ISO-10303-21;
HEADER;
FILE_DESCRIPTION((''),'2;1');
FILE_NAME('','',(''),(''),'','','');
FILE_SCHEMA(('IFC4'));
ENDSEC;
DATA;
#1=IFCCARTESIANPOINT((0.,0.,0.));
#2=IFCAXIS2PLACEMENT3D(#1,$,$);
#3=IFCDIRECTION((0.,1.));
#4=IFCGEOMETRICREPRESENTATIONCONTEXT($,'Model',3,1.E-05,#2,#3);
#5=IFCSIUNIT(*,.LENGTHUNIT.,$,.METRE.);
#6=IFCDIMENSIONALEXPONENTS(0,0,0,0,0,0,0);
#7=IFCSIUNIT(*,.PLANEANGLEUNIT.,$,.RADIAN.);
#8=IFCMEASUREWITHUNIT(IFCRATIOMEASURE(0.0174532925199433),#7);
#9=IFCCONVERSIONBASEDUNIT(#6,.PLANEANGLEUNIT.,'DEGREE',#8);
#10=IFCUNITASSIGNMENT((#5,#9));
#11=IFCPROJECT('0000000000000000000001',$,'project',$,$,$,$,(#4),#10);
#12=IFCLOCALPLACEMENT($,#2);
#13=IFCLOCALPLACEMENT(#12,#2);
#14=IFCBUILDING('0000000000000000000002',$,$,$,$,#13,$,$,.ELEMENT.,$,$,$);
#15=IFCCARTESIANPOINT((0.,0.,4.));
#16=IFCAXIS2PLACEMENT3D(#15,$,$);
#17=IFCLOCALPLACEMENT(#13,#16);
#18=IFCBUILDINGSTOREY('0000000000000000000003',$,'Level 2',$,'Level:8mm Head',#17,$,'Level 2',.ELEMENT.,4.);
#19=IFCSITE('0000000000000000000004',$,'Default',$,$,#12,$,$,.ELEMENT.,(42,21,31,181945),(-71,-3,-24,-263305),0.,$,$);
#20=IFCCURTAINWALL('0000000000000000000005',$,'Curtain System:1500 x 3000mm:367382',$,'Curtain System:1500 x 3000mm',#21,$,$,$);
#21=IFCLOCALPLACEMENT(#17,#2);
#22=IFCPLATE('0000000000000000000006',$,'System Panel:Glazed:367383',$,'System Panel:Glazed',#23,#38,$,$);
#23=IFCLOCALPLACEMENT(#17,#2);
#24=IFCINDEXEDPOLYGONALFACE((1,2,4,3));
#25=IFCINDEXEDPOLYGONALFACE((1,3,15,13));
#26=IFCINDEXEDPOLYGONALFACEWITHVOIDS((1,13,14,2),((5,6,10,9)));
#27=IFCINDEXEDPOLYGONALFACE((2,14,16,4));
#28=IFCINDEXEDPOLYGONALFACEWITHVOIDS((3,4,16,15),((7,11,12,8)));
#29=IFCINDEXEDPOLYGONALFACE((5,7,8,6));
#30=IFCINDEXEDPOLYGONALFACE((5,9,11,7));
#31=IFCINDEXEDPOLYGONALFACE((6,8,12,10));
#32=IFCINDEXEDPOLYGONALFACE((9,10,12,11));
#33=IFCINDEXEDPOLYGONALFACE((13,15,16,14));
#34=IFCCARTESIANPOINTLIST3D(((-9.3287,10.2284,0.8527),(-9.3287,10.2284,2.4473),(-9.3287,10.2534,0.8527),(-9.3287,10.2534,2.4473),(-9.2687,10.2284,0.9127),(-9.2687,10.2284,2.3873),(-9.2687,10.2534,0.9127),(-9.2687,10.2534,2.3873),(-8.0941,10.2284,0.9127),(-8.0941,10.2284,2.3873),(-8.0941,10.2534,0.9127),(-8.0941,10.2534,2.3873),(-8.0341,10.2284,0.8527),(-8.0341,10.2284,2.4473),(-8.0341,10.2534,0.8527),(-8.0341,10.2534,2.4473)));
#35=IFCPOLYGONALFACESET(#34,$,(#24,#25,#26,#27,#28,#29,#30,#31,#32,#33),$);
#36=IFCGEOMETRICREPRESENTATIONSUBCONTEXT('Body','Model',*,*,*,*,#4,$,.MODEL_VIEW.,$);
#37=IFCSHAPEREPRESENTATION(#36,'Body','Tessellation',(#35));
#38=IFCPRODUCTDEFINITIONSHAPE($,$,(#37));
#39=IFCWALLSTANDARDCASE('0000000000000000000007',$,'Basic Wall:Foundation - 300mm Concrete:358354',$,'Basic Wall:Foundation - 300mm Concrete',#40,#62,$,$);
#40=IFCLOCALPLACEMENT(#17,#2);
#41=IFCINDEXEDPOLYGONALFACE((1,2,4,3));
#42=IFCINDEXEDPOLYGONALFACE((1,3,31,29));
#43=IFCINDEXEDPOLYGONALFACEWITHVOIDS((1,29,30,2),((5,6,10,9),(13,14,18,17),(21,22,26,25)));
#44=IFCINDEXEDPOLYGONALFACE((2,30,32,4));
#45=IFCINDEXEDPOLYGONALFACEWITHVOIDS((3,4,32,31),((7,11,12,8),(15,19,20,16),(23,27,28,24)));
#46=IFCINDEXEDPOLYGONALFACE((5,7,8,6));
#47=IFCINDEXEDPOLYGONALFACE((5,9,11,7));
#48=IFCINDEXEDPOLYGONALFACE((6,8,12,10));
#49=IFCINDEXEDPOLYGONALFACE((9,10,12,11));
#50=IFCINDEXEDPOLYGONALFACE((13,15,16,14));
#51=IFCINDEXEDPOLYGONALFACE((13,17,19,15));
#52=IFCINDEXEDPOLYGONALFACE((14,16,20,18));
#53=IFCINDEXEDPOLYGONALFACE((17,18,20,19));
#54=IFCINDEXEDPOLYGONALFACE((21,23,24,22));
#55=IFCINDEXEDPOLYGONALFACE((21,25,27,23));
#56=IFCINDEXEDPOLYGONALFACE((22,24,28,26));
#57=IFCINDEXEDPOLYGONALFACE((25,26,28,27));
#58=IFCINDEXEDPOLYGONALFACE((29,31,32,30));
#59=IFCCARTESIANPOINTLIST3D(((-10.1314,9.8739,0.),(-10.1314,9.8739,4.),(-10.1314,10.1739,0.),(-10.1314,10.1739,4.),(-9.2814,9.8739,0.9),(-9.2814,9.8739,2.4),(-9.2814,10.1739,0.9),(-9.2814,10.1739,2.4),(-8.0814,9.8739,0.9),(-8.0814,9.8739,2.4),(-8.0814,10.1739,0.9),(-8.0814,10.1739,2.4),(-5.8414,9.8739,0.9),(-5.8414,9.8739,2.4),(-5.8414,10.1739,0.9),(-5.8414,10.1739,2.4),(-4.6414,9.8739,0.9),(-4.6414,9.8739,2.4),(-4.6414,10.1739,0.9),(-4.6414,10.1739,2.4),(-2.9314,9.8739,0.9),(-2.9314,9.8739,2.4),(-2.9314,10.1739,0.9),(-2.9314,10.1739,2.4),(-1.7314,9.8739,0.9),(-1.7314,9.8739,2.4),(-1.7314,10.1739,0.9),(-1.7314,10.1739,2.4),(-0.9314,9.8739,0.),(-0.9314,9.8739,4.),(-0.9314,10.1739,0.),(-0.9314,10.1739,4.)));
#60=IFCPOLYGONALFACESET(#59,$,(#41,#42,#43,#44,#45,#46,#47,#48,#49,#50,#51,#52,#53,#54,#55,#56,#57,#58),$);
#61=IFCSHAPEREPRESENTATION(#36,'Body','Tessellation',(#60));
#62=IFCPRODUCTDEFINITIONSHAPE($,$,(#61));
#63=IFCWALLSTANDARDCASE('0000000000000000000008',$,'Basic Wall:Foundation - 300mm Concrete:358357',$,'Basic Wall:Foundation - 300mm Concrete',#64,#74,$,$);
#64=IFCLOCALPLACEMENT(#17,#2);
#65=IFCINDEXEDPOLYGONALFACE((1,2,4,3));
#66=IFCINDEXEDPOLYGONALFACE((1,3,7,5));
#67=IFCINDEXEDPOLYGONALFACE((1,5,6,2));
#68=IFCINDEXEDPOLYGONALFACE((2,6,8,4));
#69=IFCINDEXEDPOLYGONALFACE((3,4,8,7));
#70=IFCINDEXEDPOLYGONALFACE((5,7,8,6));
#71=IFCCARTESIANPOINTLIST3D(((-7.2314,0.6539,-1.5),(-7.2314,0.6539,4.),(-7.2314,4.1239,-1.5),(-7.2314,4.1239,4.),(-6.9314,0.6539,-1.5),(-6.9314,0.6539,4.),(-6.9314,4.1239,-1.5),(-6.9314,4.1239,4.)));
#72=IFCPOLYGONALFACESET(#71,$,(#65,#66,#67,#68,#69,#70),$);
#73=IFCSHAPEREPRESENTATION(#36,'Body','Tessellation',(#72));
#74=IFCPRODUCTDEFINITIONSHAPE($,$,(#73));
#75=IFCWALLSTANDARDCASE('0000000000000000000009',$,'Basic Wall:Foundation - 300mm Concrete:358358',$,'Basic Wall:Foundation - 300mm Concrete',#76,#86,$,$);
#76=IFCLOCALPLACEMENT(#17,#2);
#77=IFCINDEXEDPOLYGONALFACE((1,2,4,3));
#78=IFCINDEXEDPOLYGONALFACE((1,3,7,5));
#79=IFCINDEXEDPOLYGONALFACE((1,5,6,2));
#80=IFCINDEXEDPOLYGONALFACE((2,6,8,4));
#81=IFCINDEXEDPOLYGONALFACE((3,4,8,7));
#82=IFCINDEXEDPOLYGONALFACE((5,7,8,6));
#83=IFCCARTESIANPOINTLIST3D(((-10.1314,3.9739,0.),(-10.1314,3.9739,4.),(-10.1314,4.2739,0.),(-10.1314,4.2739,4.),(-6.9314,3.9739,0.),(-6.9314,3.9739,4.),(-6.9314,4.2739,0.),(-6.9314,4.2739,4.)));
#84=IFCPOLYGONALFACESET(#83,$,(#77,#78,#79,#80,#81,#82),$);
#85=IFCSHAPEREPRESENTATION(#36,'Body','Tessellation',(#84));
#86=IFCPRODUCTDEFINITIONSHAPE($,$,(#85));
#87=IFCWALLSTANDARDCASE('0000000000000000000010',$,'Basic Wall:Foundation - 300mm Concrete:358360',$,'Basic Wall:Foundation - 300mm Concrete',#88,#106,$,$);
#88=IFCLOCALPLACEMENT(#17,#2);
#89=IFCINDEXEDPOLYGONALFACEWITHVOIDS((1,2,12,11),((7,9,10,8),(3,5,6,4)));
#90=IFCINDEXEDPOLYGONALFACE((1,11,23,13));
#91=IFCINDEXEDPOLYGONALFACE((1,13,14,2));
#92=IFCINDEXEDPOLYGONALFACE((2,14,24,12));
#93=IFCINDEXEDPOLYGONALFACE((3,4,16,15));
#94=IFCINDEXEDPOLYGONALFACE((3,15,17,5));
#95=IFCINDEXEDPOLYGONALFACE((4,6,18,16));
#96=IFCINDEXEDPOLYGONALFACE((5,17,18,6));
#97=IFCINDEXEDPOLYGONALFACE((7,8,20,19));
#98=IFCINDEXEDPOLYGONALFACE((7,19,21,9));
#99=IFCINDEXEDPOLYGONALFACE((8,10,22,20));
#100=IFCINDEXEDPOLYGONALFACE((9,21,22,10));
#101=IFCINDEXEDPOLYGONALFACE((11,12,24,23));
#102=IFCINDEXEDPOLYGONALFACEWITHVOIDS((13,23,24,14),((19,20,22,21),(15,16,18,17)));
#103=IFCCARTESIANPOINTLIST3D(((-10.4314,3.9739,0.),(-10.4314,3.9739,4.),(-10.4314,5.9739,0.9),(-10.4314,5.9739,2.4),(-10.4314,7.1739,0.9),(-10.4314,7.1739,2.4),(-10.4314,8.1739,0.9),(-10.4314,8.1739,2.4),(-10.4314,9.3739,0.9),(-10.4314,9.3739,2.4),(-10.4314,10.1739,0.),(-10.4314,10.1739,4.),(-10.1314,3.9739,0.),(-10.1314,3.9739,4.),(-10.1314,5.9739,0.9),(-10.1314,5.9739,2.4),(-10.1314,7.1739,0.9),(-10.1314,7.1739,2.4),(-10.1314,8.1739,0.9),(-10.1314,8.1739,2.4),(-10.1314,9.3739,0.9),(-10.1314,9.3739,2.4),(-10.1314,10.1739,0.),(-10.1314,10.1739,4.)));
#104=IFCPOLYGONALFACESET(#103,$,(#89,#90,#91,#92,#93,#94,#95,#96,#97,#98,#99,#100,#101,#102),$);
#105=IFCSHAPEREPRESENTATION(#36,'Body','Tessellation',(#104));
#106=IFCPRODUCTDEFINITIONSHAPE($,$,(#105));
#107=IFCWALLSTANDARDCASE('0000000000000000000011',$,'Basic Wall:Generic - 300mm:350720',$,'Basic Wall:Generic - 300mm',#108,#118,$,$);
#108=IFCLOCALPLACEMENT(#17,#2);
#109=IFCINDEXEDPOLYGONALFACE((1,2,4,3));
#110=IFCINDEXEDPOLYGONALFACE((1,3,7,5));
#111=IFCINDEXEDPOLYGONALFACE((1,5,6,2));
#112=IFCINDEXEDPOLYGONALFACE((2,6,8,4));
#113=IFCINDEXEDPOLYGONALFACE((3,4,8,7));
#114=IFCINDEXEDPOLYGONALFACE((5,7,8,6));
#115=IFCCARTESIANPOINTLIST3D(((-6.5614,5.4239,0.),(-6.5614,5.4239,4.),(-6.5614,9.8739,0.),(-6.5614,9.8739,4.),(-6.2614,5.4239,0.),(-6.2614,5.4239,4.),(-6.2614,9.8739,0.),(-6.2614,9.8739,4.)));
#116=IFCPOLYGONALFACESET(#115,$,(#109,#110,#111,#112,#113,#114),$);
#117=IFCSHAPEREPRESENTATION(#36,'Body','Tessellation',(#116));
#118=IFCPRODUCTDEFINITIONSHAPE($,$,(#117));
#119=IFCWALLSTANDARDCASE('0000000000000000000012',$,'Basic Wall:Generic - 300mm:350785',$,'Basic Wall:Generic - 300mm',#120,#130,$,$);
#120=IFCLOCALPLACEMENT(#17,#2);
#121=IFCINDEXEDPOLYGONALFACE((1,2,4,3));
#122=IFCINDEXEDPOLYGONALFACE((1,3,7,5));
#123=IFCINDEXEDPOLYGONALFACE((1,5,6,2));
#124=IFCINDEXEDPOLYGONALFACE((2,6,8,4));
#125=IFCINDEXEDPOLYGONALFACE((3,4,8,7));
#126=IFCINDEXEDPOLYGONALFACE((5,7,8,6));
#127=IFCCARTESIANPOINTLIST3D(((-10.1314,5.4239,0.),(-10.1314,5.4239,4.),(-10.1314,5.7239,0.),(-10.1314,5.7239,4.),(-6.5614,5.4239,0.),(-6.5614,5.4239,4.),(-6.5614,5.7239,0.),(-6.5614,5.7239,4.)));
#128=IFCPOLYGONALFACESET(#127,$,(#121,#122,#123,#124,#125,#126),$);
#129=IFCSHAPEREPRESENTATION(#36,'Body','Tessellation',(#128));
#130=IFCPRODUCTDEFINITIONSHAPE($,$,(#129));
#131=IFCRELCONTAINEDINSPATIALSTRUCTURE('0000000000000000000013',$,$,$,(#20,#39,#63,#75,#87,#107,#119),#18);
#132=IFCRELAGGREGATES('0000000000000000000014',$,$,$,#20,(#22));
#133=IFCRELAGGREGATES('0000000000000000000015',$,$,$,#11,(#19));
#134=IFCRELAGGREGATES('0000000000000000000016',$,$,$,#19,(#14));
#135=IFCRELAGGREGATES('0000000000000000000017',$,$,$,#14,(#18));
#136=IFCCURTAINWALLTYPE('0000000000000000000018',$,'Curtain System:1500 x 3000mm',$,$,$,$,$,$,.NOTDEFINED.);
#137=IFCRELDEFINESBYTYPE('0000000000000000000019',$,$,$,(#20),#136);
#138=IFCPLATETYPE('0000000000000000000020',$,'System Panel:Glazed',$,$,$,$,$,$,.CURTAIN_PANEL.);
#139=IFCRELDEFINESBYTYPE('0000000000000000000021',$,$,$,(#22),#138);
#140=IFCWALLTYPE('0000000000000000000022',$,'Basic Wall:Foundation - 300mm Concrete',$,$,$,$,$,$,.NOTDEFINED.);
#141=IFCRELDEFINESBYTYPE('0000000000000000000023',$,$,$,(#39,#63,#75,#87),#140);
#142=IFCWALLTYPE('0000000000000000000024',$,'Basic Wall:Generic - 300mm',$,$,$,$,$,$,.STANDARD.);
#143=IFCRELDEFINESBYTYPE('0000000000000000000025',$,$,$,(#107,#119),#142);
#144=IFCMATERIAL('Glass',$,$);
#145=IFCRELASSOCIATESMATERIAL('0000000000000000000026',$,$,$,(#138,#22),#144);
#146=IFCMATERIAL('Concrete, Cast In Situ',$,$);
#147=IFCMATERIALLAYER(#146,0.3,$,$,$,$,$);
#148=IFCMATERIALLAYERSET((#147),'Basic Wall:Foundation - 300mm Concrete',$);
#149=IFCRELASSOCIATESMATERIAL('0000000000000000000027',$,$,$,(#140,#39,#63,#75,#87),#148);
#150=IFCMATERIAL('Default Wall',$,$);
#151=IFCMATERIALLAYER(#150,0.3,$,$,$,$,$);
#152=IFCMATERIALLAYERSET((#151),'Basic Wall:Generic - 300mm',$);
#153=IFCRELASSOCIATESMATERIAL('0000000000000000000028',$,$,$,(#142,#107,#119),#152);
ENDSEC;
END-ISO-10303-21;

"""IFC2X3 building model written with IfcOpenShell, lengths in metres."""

from ifc_helpers import new_model, entity, si_unit, converted_unit, direction, frame, frame_2d, origin, place, context, subcontext, project, spatial, polyline, rectangle, outline, extrude, source, transform, mapped, material, layer, layer_set, layer_usage, type_object, type_shapes, element, aggregate, save


model = new_model("IFC2X3")

# Units and contexts
model_context = context("Model", 3, precision=1e-05, world=origin(), true_north=direction((0.0, 1.0)))
body_context = subcontext(model_context, "Body", "Model", "MODEL_VIEW")
ifc_project = project(units=[si_unit("LENGTHUNIT", "METRE"), converted_unit("PLANEANGLEUNIT", "DEGREE", entity("IfcRatioMeasure", 0.0174532925199433), si_unit("PLANEANGLEUNIT", "RADIAN"), dimensions=[0, 0, 0, 0, 0, 0, 0])], contexts=[model_context])

# Site, building, storey
site_placement = place(None, origin())
site = spatial("IfcSite", under=ifc_project, at=site_placement, Name="Default", CompositionType="ELEMENT", RefLatitude=(42, 21, 31, 181945), RefLongitude=(-71, -3, -24, -263305), RefElevation=0.0)
building_placement = place(site_placement, origin())
building = spatial("IfcBuilding", under=site, at=building_placement, CompositionType="ELEMENT")
storey_placement = place(building_placement, frame((0.0, 0.0, 4.0)))
storey = spatial("IfcBuildingStorey", under=building, at=storey_placement, Name="Level 2", ObjectType="Level:8mm Head", LongName="Level 2", CompositionType="ELEMENT", Elevation=4.0)

# Curtain wall, plate
curtain_wall_type = type_object("IfcCurtainWallType", Name="Curtain System:1500 x 3000mm", PredefinedType="NOTDEFINED")
ifc_material_1 = material(Name="Glass")
curtain_wall_1_placement = place(storey_placement, frame((0.0, 0.0, -4.0)))
curtain_wall_1 = element("IfcCurtainWall", 1, at=curtain_wall_1_placement, inside=storey, type_object=curtain_wall_type, Name="Curtain System:1500 x 3000mm:367382", ObjectType="Curtain System:1500 x 3000mm")
plate_type_1 = type_object("IfcPlateType", Name="System Panel:Glazed", PredefinedType="CURTAIN_PANEL", material=ifc_material_1)
shared_shape_1 = source(origin(), body_context, "Body", "SweptSolid", [
    extrude(outline(polyline([(-0.6473, -0.7973), (0.6473, -0.7973), (0.6473, 0.7973), (-0.6473, 0.7973), (-0.6473, -0.7973)]), holes=[polyline([(-0.5873, 0.7373), (0.5873, 0.7373), (0.5873, -0.7373), (-0.5873, -0.7373), (-0.5873, 0.7373)])]), frame((0.0, 0.0245, 0.6473), z_axis=(0.0, 1.0, 0.0), x_axis=(0.0, 0.0, 1.0)), (0.0, 0.0, 1.0), 0.025),
])
type_shapes(plate_type_1, [shared_shape_1])
plate_1_placement = place(curtain_wall_1_placement, frame((-8.0341, 10.2039, 5.65), z_axis=(-1.0, 0.0, 0.0), x_axis=(0.0, 0.0, 1.0)))
plate_1 = element("IfcPlate", 2, at=plate_1_placement, type_object=plate_type_1, material=ifc_material_1, Name="System Panel:Glazed:367383", ObjectType="System Panel:Glazed", context=body_context, shape_type="MappedRepresentation", body=[
    mapped(shared_shape_1, transform((0.0, 0.0, 0.0), scale=1.0)),
])
aggregate(curtain_wall_1, [plate_1])

# Wall, openings
ifc_material_2 = material(Name="Concrete, Cast In Situ")
ifc_layer_1 = layer(ifc_material_2, 0.3)
ifc_layer_set_1 = layer_set([ifc_layer_1], Name="Basic Wall:Foundation - 300mm Concrete")
ifc_layer_usage_1 = layer_usage(ifc_layer_set_1, "AXIS2", "NEGATIVE", 0.15)
wall_type_1 = type_object("IfcWallType", Name="Basic Wall:Foundation - 300mm Concrete", PredefinedType="NOTDEFINED", material=ifc_layer_set_1)
wall_1_placement = place(storey_placement, frame((-10.1314, 10.0239, 0.0)))
wall_1 = element("IfcWallStandardCase", 3, at=wall_1_placement, inside=storey, type_object=wall_type_1, material=ifc_layer_usage_1, Name="Basic Wall:Foundation - 300mm Concrete:358354", ObjectType="Basic Wall:Foundation - 300mm Concrete", context=body_context, shape_type="SweptSolid", body=[
    extrude(rectangle(XDim=9.2, YDim=0.3, at=frame_2d((4.6, 0.0), x_axis=(-1.0, 0.0))), origin(), (0.0, 0.0, 1.0), 4.0),
])
opening_1_placement = place(wall_1_placement, frame((2.05, 0.15, 0.9)))
element("IfcOpeningElement", 4, at=opening_1_placement, cuts=wall_1, ObjectType="Opening", context=body_context, shape_type="SweptSolid", body=[
    extrude(rectangle(XDim=1.5, YDim=1.2, at=frame_2d((0.75, 0.6), x_axis=(-1.0, 0.0))), frame((0.0, 0.0, 0.0), z_axis=(0.0, -1.0, 0.0), x_axis=(0.0, 0.0, 1.0)), (0.0, 0.0, 1.0), 0.3),
])
opening_2_placement = place(wall_1_placement, frame((5.49, 0.15, 0.9)))
element("IfcOpeningElement", 5, at=opening_2_placement, cuts=wall_1, ObjectType="Opening", context=body_context, shape_type="SweptSolid", body=[
    extrude(rectangle(XDim=1.5, YDim=1.2, at=frame_2d((0.75, 0.6), x_axis=(-1.0, 0.0))), frame((0.0, 0.0, 0.0), z_axis=(0.0, -1.0, 0.0), x_axis=(0.0, 0.0, 1.0)), (0.0, 0.0, 1.0), 0.3),
])
opening_3_placement = place(wall_1_placement, frame((8.4, 0.15, 0.9)))
element("IfcOpeningElement", 6, at=opening_3_placement, cuts=wall_1, ObjectType="Opening", context=body_context, shape_type="SweptSolid", body=[
    extrude(rectangle(XDim=1.5, YDim=1.2, at=frame_2d((0.75, 0.6), x_axis=(-1.0, 0.0))), frame((0.0, 0.0, 0.0), z_axis=(0.0, -1.0, 0.0), x_axis=(0.0, 0.0, 1.0)), (0.0, 0.0, 1.0), 0.3),
])

# Walls
ifc_layer_usage_2 = layer_usage(ifc_layer_set_1, "AXIS2", "NEGATIVE", 0.15)
wall_2_placement = place(storey_placement, frame((-7.0814, 0.6539, -1.5), z_axis=(0.0, 0.0, 1.0), x_axis=(0.0, 1.0, 0.0)))
element("IfcWallStandardCase", 7, at=wall_2_placement, inside=storey, type_object=wall_type_1, material=ifc_layer_usage_2, Name="Basic Wall:Foundation - 300mm Concrete:358357", ObjectType="Basic Wall:Foundation - 300mm Concrete", context=body_context, shape_type="SweptSolid", body=[
    extrude(rectangle(XDim=3.47, YDim=0.3, at=frame_2d((1.735, 0.0), x_axis=(-1.0, 0.0))), origin(), (0.0, 0.0, 1.0), 5.5),
])
ifc_layer_usage_3 = layer_usage(ifc_layer_set_1, "AXIS2", "NEGATIVE", 0.15)
wall_3_placement = place(storey_placement, frame((-6.9314, 4.1239, 0.0), z_axis=(0.0, 0.0, 1.0), x_axis=(-1.0, 0.0, 0.0)))
element("IfcWallStandardCase", 8, at=wall_3_placement, inside=storey, type_object=wall_type_1, material=ifc_layer_usage_3, Name="Basic Wall:Foundation - 300mm Concrete:358358", ObjectType="Basic Wall:Foundation - 300mm Concrete", context=body_context, shape_type="SweptSolid", body=[
    extrude(rectangle(XDim=3.2, YDim=0.3, at=frame_2d((1.6, 0.0), x_axis=(-1.0, 0.0))), origin(), (0.0, 0.0, 1.0), 4.0),
])

# Wall, openings
ifc_layer_usage_4 = layer_usage(ifc_layer_set_1, "AXIS2", "NEGATIVE", 0.15)
wall_4_placement = place(storey_placement, frame((-10.2814, 3.9739, 0.0), z_axis=(0.0, 0.0, 1.0), x_axis=(0.0, 1.0, 0.0)))
wall_4 = element("IfcWallStandardCase", 9, at=wall_4_placement, inside=storey, type_object=wall_type_1, material=ifc_layer_usage_4, Name="Basic Wall:Foundation - 300mm Concrete:358360", ObjectType="Basic Wall:Foundation - 300mm Concrete", context=body_context, shape_type="SweptSolid", body=[
    extrude(rectangle(XDim=6.2, YDim=0.3, at=frame_2d((3.1, 0.0), x_axis=(-1.0, 0.0))), origin(), (0.0, 0.0, 1.0), 4.0),
])
opening_4_placement = place(wall_4_placement, frame((5.4, 0.15, 0.9)))
element("IfcOpeningElement", 10, at=opening_4_placement, cuts=wall_4, ObjectType="Opening", context=body_context, shape_type="SweptSolid", body=[
    extrude(rectangle(XDim=1.5, YDim=1.2, at=frame_2d((0.75, 0.6), x_axis=(-1.0, 0.0))), frame((0.0, 0.0, 0.0), z_axis=(0.0, -1.0, 0.0), x_axis=(0.0, 0.0, 1.0)), (0.0, 0.0, 1.0), 0.3),
])
opening_5_placement = place(wall_4_placement, frame((3.2, 0.15, 0.9)))
element("IfcOpeningElement", 11, at=opening_5_placement, cuts=wall_4, ObjectType="Opening", context=body_context, shape_type="SweptSolid", body=[
    extrude(rectangle(XDim=1.5, YDim=1.2, at=frame_2d((0.75, 0.6), x_axis=(-1.0, 0.0))), frame((0.0, 0.0, 0.0), z_axis=(0.0, -1.0, 0.0), x_axis=(0.0, 0.0, 1.0)), (0.0, 0.0, 1.0), 0.3),
])

# Walls
ifc_material_3 = material(Name="Default Wall")
ifc_layer_2 = layer(ifc_material_3, 0.3)
ifc_layer_set_2 = layer_set([ifc_layer_2], Name="Basic Wall:Generic - 300mm")
ifc_layer_usage_5 = layer_usage(ifc_layer_set_2, "AXIS2", "NEGATIVE", 0.15)
wall_type_2 = type_object("IfcWallType", Name="Basic Wall:Generic - 300mm", PredefinedType="STANDARD", material=ifc_layer_set_2)
wall_5_placement = place(storey_placement, frame((-6.4114, 9.8739, 0.0), z_axis=(0.0, 0.0, 1.0), x_axis=(0.0, -1.0, 0.0)))
element("IfcWallStandardCase", 12, at=wall_5_placement, inside=storey, type_object=wall_type_2, material=ifc_layer_usage_5, Name="Basic Wall:Generic - 300mm:350720", ObjectType="Basic Wall:Generic - 300mm", context=body_context, shape_type="SweptSolid", body=[
    extrude(rectangle(XDim=4.45, YDim=0.3, at=frame_2d((2.225, 0.0), x_axis=(-1.0, 0.0))), origin(), (0.0, 0.0, 1.0), 4.0),
])
ifc_layer_usage_6 = layer_usage(ifc_layer_set_2, "AXIS2", "NEGATIVE", 0.15)
wall_6_placement = place(storey_placement, frame((-6.5614, 5.5739, 0.0), z_axis=(0.0, 0.0, 1.0), x_axis=(-1.0, 0.0, 0.0)))
element("IfcWallStandardCase", 13, at=wall_6_placement, inside=storey, type_object=wall_type_2, material=ifc_layer_usage_6, Name="Basic Wall:Generic - 300mm:350785", ObjectType="Basic Wall:Generic - 300mm", context=body_context, shape_type="SweptSolid", body=[
    extrude(rectangle(XDim=3.57, YDim=0.3, at=frame_2d((1.785, 0.0), x_axis=(-1.0, 0.0))), origin(), (0.0, 0.0, 1.0), 4.0),
])

save(model, "model.ifc")
